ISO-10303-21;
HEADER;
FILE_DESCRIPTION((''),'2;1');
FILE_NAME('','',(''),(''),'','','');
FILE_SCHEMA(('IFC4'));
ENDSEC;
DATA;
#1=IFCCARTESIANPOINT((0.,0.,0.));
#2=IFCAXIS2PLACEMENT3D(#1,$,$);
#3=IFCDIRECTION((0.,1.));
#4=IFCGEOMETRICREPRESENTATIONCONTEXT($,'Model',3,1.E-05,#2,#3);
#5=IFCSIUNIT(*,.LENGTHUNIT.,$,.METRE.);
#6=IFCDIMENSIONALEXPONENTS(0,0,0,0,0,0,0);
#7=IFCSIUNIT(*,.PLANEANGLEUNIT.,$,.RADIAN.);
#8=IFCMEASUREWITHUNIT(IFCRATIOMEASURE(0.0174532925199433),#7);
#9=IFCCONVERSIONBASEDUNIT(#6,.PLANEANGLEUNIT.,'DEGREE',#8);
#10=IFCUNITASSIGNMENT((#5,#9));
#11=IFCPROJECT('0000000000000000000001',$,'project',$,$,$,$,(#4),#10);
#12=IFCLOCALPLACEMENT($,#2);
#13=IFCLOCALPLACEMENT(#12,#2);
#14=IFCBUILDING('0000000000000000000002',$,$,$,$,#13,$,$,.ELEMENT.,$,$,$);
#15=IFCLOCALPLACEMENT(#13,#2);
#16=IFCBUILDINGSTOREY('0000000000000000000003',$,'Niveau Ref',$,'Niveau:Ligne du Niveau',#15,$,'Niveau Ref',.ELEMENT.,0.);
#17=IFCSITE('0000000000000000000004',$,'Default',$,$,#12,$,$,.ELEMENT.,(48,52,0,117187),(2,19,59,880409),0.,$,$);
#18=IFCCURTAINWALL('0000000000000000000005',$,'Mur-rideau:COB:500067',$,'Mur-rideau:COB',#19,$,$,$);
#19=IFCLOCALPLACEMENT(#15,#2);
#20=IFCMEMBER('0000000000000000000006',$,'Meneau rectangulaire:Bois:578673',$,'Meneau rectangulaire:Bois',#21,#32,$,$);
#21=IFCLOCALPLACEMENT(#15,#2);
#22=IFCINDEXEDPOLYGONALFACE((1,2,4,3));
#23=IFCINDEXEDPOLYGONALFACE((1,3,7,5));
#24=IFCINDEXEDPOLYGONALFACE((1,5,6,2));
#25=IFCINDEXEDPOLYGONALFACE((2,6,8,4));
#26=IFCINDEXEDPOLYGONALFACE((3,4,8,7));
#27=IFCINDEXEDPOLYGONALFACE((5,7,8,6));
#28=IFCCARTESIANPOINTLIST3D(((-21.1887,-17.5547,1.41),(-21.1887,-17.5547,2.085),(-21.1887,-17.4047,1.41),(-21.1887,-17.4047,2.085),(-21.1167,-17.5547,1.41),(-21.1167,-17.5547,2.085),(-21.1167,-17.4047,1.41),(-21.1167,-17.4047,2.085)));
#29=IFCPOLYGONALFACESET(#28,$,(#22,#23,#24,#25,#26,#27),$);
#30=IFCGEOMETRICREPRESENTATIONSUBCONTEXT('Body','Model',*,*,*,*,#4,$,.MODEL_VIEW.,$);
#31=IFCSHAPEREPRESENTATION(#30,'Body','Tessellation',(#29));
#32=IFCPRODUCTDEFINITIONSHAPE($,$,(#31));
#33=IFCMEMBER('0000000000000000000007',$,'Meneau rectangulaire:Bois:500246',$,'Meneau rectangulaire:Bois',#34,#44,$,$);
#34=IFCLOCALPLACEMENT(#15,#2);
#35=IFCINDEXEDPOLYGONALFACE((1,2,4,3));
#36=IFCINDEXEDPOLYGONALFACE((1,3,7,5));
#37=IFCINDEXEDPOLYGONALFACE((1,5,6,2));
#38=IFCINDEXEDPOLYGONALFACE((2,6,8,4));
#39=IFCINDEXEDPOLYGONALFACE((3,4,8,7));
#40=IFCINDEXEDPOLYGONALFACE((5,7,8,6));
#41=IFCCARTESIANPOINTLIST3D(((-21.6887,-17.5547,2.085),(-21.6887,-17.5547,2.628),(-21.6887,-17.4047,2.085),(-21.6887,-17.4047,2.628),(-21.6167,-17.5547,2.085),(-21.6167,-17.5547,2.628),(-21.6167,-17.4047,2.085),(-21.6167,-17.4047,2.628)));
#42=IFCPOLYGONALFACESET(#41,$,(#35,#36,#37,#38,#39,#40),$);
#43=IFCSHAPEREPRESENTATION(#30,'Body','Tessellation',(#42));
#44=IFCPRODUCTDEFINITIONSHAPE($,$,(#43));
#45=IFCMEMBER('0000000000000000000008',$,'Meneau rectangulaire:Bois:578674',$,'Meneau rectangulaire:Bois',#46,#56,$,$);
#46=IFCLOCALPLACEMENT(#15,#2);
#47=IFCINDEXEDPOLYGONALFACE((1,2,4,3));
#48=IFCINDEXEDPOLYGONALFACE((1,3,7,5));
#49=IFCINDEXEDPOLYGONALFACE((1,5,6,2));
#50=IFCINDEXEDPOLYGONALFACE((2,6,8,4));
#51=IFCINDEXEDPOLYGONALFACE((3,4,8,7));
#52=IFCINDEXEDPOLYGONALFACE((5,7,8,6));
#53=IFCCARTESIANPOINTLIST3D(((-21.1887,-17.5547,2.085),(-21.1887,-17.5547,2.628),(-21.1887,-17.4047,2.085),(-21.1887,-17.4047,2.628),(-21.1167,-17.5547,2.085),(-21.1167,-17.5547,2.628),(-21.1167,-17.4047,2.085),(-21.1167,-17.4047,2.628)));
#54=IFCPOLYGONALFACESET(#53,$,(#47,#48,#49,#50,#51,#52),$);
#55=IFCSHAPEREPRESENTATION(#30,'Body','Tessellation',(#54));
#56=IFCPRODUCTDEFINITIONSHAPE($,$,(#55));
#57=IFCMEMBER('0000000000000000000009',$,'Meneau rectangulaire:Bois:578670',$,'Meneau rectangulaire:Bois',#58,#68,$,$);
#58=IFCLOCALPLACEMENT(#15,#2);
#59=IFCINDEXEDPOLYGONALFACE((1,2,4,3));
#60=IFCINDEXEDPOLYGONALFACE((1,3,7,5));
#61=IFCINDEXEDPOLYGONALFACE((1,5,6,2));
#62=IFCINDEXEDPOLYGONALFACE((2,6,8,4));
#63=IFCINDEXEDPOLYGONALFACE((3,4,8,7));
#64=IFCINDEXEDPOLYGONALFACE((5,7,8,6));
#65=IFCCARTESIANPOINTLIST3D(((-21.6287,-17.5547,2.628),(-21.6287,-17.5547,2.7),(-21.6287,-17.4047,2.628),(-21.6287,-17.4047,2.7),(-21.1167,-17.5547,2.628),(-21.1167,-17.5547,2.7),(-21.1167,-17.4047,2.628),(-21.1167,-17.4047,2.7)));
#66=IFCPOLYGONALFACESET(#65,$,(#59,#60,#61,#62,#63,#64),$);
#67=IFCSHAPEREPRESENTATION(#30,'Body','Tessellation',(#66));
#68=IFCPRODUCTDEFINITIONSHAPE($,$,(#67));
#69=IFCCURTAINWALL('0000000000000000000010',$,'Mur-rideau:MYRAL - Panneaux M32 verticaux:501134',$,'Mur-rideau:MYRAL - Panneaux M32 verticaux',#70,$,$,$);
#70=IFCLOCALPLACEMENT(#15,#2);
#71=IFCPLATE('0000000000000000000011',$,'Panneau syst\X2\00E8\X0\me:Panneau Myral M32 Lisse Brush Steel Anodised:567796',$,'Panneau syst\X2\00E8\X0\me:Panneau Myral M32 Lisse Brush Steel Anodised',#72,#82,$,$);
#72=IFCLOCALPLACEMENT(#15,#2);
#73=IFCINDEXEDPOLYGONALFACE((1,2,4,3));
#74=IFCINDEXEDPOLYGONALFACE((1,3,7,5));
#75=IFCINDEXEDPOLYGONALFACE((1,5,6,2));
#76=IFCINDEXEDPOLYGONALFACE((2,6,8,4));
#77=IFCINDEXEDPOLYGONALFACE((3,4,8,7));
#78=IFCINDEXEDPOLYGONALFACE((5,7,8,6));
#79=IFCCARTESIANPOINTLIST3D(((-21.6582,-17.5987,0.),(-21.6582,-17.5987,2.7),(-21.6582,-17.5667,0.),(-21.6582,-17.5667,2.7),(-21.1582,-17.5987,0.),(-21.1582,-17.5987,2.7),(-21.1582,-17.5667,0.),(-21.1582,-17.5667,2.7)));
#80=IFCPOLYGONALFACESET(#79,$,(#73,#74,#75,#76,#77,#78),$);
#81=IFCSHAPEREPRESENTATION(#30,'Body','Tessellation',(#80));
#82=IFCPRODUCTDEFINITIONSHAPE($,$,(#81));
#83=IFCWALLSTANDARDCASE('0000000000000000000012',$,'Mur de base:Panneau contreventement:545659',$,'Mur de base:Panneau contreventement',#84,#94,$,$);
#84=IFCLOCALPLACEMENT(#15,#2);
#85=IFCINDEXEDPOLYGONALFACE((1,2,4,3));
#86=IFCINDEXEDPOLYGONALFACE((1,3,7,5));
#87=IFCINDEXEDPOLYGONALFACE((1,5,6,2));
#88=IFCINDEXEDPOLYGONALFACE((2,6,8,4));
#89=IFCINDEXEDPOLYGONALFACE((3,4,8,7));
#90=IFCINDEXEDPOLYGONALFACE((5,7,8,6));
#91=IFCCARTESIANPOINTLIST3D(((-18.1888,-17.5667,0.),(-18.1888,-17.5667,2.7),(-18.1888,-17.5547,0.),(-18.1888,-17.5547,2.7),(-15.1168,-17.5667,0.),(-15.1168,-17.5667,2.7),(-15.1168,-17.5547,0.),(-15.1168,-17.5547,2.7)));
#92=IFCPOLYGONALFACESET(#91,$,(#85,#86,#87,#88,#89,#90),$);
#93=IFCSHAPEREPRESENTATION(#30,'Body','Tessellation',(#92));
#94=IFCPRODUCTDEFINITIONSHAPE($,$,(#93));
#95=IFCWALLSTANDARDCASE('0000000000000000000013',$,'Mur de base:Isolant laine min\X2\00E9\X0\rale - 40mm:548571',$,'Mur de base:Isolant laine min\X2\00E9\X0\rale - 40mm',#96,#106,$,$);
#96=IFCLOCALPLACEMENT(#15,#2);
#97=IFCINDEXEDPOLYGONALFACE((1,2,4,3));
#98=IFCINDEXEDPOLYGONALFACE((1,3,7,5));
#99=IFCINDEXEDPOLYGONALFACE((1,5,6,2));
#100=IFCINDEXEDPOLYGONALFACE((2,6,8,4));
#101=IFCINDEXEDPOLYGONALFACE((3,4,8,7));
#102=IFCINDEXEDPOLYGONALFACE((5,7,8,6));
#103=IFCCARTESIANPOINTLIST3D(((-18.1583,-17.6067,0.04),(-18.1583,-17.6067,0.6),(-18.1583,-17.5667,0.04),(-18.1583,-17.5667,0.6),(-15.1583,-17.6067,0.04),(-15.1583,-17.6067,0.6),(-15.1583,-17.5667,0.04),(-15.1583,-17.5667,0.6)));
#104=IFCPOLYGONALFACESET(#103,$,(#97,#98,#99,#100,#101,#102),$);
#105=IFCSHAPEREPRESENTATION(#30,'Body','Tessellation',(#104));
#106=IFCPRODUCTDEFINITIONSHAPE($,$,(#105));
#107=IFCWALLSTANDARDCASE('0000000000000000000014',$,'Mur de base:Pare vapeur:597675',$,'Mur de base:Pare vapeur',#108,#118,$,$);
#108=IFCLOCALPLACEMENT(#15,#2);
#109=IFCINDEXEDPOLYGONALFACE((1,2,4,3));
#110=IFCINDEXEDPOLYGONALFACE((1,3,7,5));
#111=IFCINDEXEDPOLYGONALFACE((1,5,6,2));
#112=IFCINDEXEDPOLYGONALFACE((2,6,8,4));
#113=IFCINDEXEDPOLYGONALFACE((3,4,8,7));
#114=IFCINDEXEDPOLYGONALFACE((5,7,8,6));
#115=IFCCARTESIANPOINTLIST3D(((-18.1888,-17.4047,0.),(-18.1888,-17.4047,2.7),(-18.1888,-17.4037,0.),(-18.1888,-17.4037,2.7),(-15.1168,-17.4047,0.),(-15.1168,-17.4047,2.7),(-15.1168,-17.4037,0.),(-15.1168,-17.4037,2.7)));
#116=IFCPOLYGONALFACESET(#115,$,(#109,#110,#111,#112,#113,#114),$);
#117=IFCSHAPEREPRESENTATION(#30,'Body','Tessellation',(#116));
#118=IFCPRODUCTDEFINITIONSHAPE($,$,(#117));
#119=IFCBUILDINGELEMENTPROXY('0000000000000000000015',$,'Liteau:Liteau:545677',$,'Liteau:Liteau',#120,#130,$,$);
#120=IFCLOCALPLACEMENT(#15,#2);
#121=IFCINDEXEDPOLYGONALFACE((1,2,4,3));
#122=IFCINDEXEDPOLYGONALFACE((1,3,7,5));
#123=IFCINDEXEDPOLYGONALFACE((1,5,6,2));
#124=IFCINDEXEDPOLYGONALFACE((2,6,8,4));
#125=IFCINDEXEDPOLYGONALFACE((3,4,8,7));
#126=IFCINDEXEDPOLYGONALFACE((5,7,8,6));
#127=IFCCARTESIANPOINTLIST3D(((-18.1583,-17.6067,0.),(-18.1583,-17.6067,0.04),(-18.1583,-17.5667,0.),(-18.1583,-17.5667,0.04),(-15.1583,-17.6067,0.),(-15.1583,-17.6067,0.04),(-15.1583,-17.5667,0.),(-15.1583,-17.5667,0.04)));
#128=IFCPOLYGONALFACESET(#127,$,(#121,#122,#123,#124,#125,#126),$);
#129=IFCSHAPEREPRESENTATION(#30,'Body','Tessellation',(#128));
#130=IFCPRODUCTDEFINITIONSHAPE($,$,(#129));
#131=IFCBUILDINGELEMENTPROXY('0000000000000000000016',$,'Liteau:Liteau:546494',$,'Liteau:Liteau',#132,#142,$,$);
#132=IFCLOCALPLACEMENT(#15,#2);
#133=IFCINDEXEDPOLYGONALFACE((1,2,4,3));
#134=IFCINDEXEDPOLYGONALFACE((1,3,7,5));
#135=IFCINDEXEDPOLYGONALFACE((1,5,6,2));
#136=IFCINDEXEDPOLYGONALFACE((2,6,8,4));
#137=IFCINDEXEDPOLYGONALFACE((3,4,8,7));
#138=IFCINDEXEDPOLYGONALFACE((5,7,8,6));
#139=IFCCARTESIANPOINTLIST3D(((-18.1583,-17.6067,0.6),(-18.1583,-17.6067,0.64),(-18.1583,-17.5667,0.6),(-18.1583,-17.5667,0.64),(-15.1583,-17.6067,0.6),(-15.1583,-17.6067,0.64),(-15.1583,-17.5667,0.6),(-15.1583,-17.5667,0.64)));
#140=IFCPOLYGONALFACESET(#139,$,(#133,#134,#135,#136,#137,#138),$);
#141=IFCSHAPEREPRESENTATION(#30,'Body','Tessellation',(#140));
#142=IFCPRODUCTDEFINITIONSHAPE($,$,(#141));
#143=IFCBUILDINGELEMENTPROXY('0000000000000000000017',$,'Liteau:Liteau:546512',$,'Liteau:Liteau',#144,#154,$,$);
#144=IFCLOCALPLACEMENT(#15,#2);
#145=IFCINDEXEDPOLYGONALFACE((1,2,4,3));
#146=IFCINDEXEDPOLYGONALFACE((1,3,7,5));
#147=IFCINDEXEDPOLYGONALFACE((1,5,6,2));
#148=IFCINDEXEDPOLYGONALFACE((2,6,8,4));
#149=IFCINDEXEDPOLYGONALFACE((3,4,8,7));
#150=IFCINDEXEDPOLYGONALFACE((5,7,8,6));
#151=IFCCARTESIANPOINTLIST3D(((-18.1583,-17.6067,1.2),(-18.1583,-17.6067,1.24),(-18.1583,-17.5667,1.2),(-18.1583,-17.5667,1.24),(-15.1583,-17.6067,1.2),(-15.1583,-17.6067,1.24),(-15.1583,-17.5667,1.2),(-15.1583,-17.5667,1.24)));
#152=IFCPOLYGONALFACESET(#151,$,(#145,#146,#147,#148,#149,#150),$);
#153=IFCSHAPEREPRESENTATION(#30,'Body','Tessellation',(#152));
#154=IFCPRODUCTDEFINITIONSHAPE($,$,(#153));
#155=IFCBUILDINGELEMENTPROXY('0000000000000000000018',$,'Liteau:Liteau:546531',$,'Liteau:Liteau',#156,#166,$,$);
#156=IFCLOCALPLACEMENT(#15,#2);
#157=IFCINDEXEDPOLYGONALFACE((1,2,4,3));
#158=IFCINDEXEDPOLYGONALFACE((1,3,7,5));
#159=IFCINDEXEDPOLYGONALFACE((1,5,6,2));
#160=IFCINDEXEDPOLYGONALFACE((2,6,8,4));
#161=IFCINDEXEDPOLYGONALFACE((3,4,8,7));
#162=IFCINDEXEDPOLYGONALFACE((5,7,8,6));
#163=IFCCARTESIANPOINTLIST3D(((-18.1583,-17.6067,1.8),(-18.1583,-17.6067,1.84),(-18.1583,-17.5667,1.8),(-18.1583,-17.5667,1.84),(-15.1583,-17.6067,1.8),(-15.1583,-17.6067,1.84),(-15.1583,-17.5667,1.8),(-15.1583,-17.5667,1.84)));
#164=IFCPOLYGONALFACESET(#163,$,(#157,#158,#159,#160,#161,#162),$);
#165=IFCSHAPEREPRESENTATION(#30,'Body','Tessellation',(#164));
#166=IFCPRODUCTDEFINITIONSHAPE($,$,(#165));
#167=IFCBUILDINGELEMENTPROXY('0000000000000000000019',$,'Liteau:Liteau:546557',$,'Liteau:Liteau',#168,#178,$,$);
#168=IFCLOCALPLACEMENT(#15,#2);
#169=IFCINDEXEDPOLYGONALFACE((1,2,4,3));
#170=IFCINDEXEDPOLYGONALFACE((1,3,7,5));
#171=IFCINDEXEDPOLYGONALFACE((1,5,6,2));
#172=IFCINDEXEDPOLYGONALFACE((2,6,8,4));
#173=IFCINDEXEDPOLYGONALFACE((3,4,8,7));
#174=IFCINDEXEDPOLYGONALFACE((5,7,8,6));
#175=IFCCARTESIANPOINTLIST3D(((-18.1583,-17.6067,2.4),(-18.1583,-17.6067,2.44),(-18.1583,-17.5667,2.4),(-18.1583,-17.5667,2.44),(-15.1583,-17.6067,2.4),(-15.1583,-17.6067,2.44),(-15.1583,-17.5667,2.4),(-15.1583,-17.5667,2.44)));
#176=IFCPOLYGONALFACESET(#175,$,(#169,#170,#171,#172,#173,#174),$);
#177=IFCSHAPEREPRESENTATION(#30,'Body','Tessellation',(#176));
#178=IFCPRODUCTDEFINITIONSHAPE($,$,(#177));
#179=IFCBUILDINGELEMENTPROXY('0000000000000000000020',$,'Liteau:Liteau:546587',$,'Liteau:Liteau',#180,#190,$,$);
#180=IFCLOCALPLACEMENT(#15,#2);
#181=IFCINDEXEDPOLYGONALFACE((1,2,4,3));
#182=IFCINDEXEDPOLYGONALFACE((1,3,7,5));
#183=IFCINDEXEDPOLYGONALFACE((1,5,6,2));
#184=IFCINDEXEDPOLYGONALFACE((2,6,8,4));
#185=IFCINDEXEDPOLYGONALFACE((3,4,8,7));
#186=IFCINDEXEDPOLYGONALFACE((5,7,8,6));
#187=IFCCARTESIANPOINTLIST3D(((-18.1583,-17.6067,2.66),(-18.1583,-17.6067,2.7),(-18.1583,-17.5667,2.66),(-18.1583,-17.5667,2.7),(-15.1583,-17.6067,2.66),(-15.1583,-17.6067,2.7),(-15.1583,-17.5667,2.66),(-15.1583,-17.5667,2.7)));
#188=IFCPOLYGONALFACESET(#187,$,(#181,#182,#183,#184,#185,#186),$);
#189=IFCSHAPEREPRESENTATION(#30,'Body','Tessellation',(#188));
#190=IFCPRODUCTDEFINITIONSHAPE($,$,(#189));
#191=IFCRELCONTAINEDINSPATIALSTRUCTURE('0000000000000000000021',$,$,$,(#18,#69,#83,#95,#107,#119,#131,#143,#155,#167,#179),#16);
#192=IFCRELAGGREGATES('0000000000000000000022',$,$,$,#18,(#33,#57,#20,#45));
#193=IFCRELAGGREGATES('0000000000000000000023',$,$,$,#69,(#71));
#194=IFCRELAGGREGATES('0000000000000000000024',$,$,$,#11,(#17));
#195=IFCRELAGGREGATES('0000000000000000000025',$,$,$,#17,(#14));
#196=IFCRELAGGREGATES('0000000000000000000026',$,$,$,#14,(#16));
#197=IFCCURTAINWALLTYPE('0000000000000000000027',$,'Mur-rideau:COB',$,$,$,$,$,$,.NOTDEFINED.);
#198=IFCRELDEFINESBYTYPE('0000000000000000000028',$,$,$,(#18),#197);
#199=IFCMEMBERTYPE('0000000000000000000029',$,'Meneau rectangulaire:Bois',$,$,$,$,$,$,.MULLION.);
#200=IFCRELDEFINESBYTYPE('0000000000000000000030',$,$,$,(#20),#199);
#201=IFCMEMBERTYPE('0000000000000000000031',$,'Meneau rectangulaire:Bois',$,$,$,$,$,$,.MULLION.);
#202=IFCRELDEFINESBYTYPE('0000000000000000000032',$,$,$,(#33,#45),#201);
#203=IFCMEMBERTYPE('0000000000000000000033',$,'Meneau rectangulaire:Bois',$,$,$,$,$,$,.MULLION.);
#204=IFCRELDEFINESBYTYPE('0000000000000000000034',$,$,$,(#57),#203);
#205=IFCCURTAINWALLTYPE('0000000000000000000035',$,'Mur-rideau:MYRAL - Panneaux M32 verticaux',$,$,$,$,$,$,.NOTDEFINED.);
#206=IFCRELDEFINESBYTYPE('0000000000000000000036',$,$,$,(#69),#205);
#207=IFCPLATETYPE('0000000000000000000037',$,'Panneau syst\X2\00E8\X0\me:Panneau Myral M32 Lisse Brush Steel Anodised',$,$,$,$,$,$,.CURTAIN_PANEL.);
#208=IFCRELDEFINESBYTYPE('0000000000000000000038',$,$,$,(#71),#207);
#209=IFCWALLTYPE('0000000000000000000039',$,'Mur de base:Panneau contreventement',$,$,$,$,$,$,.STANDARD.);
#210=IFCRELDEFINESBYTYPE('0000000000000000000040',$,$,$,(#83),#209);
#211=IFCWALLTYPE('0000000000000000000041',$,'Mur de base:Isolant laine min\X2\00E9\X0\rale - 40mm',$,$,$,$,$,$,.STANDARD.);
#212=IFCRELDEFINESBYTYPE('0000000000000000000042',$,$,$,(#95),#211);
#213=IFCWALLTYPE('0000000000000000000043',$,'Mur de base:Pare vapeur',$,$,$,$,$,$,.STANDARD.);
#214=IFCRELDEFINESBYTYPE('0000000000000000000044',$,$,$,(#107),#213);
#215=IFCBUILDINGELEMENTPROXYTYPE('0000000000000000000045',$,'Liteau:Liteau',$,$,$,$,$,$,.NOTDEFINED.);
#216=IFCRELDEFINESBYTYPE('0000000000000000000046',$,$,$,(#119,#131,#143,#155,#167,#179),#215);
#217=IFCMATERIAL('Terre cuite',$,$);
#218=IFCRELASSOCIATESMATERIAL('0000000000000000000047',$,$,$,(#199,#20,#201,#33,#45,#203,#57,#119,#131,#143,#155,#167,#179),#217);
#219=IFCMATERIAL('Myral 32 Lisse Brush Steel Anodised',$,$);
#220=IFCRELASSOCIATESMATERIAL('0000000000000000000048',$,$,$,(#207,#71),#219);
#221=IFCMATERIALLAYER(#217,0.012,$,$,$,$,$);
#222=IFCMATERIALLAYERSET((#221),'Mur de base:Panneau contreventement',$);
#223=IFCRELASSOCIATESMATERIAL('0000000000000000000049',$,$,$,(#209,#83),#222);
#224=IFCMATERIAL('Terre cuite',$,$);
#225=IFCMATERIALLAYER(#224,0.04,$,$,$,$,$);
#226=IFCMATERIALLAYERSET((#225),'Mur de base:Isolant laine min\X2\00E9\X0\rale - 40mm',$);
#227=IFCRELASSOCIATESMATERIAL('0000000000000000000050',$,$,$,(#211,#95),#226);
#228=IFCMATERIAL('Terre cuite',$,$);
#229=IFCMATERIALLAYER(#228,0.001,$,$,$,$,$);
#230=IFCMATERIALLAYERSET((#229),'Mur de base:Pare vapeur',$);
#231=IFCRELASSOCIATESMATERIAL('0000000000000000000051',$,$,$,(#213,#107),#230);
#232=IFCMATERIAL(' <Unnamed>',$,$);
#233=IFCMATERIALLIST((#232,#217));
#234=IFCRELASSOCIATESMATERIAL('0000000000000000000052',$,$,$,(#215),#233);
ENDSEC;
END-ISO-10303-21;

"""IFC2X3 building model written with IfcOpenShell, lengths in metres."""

from ifc_helpers import new_model, entity, si_unit, converted_unit, direction, frame, frame_2d, origin, origin_2d_with_axis, place, context, subcontext, project, spatial, rectangle, extrude, source, transform, mapped, material, material_list, layer, layer_set, layer_usage, type_object, type_shapes, element, aggregate, save


model = new_model("IFC2X3")

# Units and contexts
model_context = context("Model", 3, precision=1e-05, world=origin(), true_north=direction((0.0, 1.0)))
body_context = subcontext(model_context, "Body", "Model", "MODEL_VIEW")
ifc_project = project(units=[si_unit("LENGTHUNIT", "METRE"), converted_unit("PLANEANGLEUNIT", "DEGREE", entity("IfcRatioMeasure", 0.0174532925199433), si_unit("PLANEANGLEUNIT", "RADIAN"), dimensions=[0, 0, 0, 0, 0, 0, 0])], contexts=[model_context])

# Site, building, storey
site_placement = place(None, origin())
site = spatial("IfcSite", under=ifc_project, at=site_placement, Name="Default", CompositionType="ELEMENT", RefLatitude=(48, 52, 0, 117187), RefLongitude=(2, 19, 59, 880409), RefElevation=0.0)
building_placement = place(site_placement, origin())
building = spatial("IfcBuilding", under=site, at=building_placement, CompositionType="ELEMENT")
storey_placement = place(building_placement, origin())
storey = spatial("IfcBuildingStorey", under=building, at=storey_placement, Name="Niveau Ref", ObjectType="Niveau:Ligne du Niveau", LongName="Niveau Ref", CompositionType="ELEMENT", Elevation=0.0)

# Curtain wall, members
curtain_wall_type_1 = type_object("IfcCurtainWallType", Name="Mur-rideau:COB", PredefinedType="NOTDEFINED")
ifc_material_1 = material(Name="Terre cuite")
curtain_wall_1_placement = place(storey_placement, origin())
curtain_wall_1 = element("IfcCurtainWall", 1, at=curtain_wall_1_placement, inside=storey, type_object=curtain_wall_type_1, Name="Mur-rideau:COB:500067", ObjectType="Mur-rideau:COB")
member_type_1 = type_object("IfcMemberType", Name="Meneau rectangulaire:Bois", PredefinedType="MULLION", material=ifc_material_1)
shared_shape_1 = source(origin(), body_context, "Body", "SweptSolid", [
    extrude(rectangle(XDim=0.15, YDim=0.072, at=origin_2d_with_axis()), frame((-0.024, 0.0, -0.675), z_axis=(0.0, 0.0, 1.0), x_axis=(0.0, -1.0, 0.0)), (0.0, 0.0, 1.0), 0.675),
])
type_shapes(member_type_1, [shared_shape_1])
member_1_placement = place(storey_placement, frame((-21.1287, -17.4797, 1.41), z_axis=(0.0, 0.0, -1.0), x_axis=(1.0, 0.0, 0.0)))
member_1 = element("IfcMember", 2, at=member_1_placement, type_object=member_type_1, material=ifc_material_1, Name="Meneau rectangulaire:Bois:578673", ObjectType="Meneau rectangulaire:Bois", context=body_context, shape_type="MappedRepresentation", body=[
    mapped(shared_shape_1, transform((0.0, 0.0, 0.0), scale=1.0)),
])
member_type_2 = type_object("IfcMemberType", Name="Meneau rectangulaire:Bois", PredefinedType="MULLION", material=ifc_material_1)
shared_shape_2 = source(origin(), body_context, "Body", "SweptSolid", [
    extrude(rectangle(XDim=0.15, YDim=0.072, at=origin_2d_with_axis()), frame((-0.024, 0.0, -0.543), z_axis=(0.0, 0.0, 1.0), x_axis=(0.0, -1.0, 0.0)), (0.0, 0.0, 1.0), 0.543),
])
type_shapes(member_type_2, [shared_shape_2])
member_2_placement = place(storey_placement, frame((-21.6287, -17.4797, 2.085), z_axis=(0.0, 0.0, -1.0), x_axis=(1.0, 0.0, 0.0)))
member_2 = element("IfcMember", 3, at=member_2_placement, type_object=member_type_2, material=ifc_material_1, Name="Meneau rectangulaire:Bois:500246", ObjectType="Meneau rectangulaire:Bois", context=body_context, shape_type="MappedRepresentation", body=[
    mapped(shared_shape_2, transform((0.0, 0.0, 0.0), scale=1.0)),
])
member_3_placement = place(storey_placement, frame((-21.1287, -17.4797, 2.085), z_axis=(0.0, 0.0, -1.0), x_axis=(1.0, 0.0, 0.0)))
member_3 = element("IfcMember", 4, at=member_3_placement, type_object=member_type_2, material=ifc_material_1, Name="Meneau rectangulaire:Bois:578674", ObjectType="Meneau rectangulaire:Bois", context=body_context, shape_type="MappedRepresentation", body=[
    mapped(shared_shape_2, transform((0.0, 0.0, 0.0), scale=1.0)),
])
member_type_3 = type_object("IfcMemberType", Name="Meneau rectangulaire:Bois", PredefinedType="MULLION", material=ifc_material_1)
shared_shape_3 = source(origin(), body_context, "Body", "SweptSolid", [
    extrude(rectangle(XDim=0.15, YDim=0.072, at=origin_2d_with_axis()), frame((-0.036, 0.0, -0.512), z_axis=(0.0, 0.0, 1.0), x_axis=(0.0, -1.0, 0.0)), (0.0, 0.0, 1.0), 0.512),
])
type_shapes(member_type_3, [shared_shape_3])
member_4_placement = place(storey_placement, frame((-21.1167, -17.4797, 2.7), z_axis=(1.0, 0.0, 0.0), x_axis=(0.0, 0.0, 1.0)))
member_4 = element("IfcMember", 5, at=member_4_placement, type_object=member_type_3, material=ifc_material_1, Name="Meneau rectangulaire:Bois:578670", ObjectType="Meneau rectangulaire:Bois", context=body_context, shape_type="MappedRepresentation", body=[
    mapped(shared_shape_3, transform((0.0, 0.0, 0.0), scale=1.0)),
])
aggregate(curtain_wall_1, [member_2, member_4, member_1, member_3])

# Curtain wall, plate
curtain_wall_type_2 = type_object("IfcCurtainWallType", Name="Mur-rideau:MYRAL - Panneaux M32 verticaux", PredefinedType="NOTDEFINED")
curtain_wall_2_placement = place(storey_placement, origin())
curtain_wall_2 = element("IfcCurtainWall", 6, at=curtain_wall_2_placement, inside=storey, type_object=curtain_wall_type_2, Name="Mur-rideau:MYRAL - Panneaux M32 verticaux:501134", ObjectType="Mur-rideau:MYRAL - Panneaux M32 verticaux")
ifc_material_2 = material(Name="Myral 32 Lisse Brush Steel Anodised")
plate_type = type_object("IfcPlateType", Name="Panneau système:Panneau Myral M32 Lisse Brush Steel Anodised", PredefinedType="CURTAIN_PANEL", material=ifc_material_2)
shared_shape_4 = source(origin(), body_context, "Body", "SweptSolid", [
    extrude(rectangle(XDim=0.032, YDim=0.5, at=origin_2d_with_axis()), frame((0.0, -0.016, 0.0), z_axis=(0.0, 0.0, 1.0), x_axis=(0.0, 1.0, 0.0)), (0.0, 0.0, 1.0), 2.7),
])
type_shapes(plate_type, [shared_shape_4])
plate_placement = place(curtain_wall_2_placement, frame((-21.4082, -17.5667, 0.0)))
plate = element("IfcPlate", 7, at=plate_placement, type_object=plate_type, material=ifc_material_2, Name="Panneau système:Panneau Myral M32 Lisse Brush Steel Anodised:567796", ObjectType="Panneau système:Panneau Myral M32 Lisse Brush Steel Anodised", context=body_context, shape_type="MappedRepresentation", body=[
    mapped(shared_shape_4, transform((0.0, 0.0, 0.0), scale=1.0)),
])
aggregate(curtain_wall_2, [plate])

# Walls
ifc_layer_1 = layer(ifc_material_1, 0.012)
ifc_layer_set_1 = layer_set([ifc_layer_1], Name="Mur de base:Panneau contreventement")
ifc_layer_usage_1 = layer_usage(ifc_layer_set_1, "AXIS2", "NEGATIVE", 0.006)
wall_type_1 = type_object("IfcWallType", Name="Mur de base:Panneau contreventement", PredefinedType="STANDARD", material=ifc_layer_set_1)
wall_1_placement = place(storey_placement, frame((-18.1888, -17.5607, 0.0)))
element("IfcWallStandardCase", 8, at=wall_1_placement, inside=storey, type_object=wall_type_1, material=ifc_layer_usage_1, Name="Mur de base:Panneau contreventement:545659", ObjectType="Mur de base:Panneau contreventement", context=body_context, shape_type="SweptSolid", body=[
    extrude(rectangle(XDim=3.072, YDim=0.012, at=frame_2d((1.536, 0.0), x_axis=(-1.0, 0.0))), origin(), (0.0, 0.0, 1.0), 2.7),
])
ifc_material_3 = material(Name="Terre cuite")
ifc_layer_2 = layer(ifc_material_3, 0.04)
ifc_layer_set_2 = layer_set([ifc_layer_2], Name="Mur de base:Isolant laine minérale - 40mm")
ifc_layer_usage_2 = layer_usage(ifc_layer_set_2, "AXIS2", "NEGATIVE", 0.02)
wall_type_2 = type_object("IfcWallType", Name="Mur de base:Isolant laine minérale - 40mm", PredefinedType="STANDARD", material=ifc_layer_set_2)
wall_2_placement = place(storey_placement, frame((-18.1583, -17.5867, 0.04)))
element("IfcWallStandardCase", 9, at=wall_2_placement, inside=storey, type_object=wall_type_2, material=ifc_layer_usage_2, Name="Mur de base:Isolant laine minérale - 40mm:548571", ObjectType="Mur de base:Isolant laine minérale - 40mm", context=body_context, shape_type="SweptSolid", body=[
    extrude(rectangle(XDim=3.0, YDim=0.04, at=frame_2d((1.5, 0.0), x_axis=(-1.0, 0.0))), origin(), (0.0, 0.0, 1.0), 0.56),
])
ifc_material_4 = material(Name="Terre cuite")
ifc_layer_3 = layer(ifc_material_4, 0.001)
ifc_layer_set_3 = layer_set([ifc_layer_3], Name="Mur de base:Pare vapeur")
ifc_layer_usage_3 = layer_usage(ifc_layer_set_3, "AXIS2", "NEGATIVE", 0.0005)
wall_type_3 = type_object("IfcWallType", Name="Mur de base:Pare vapeur", PredefinedType="STANDARD", material=ifc_layer_set_3)
wall_3_placement = place(storey_placement, frame((-18.1888, -17.4042, 0.0)))
element("IfcWallStandardCase", 10, at=wall_3_placement, inside=storey, type_object=wall_type_3, material=ifc_layer_usage_3, Name="Mur de base:Pare vapeur:597675", ObjectType="Mur de base:Pare vapeur", context=body_context, shape_type="SweptSolid", body=[
    extrude(rectangle(XDim=3.072, YDim=0.001, at=frame_2d((1.536, 0.0), x_axis=(-1.0, 0.0))), origin(), (0.0, 0.0, 1.0), 2.7),
])

# Building element proxies
ifc_material_5 = material(Name=" <Unnamed>")
ifc_material_list = material_list([ifc_material_5, ifc_material_1])
building_element_proxy_type = type_object("IfcBuildingElementProxyType", Name="Liteau:Liteau", PredefinedType="NOTDEFINED", material=ifc_material_list)
shared_shape_5 = source(origin(), body_context, "Body", "SweptSolid", [
    extrude(rectangle(XDim=3.0, YDim=0.04, at=origin_2d_with_axis()), frame((1.5, -0.02, 0.0), z_axis=(0.0, 0.0, 1.0), x_axis=(-1.0, 0.0, 0.0)), (0.0, 0.0, 1.0), 0.04),
])
type_shapes(building_element_proxy_type, [shared_shape_5])
for number, where, name in (
    (11, (-18.1583, -17.5667, 0.0), "Liteau:Liteau:545677"),
    (12, (-18.1583, -17.5667, 0.6), "Liteau:Liteau:546494"),
    (13, (-18.1583, -17.5667, 1.2), "Liteau:Liteau:546512"),
    (14, (-18.1583, -17.5667, 1.8), "Liteau:Liteau:546531"),
    (15, (-18.1583, -17.5667, 2.4), "Liteau:Liteau:546557"),
    (16, (-18.1583, -17.5667, 2.66), "Liteau:Liteau:546587"),
):
    element("IfcBuildingElementProxy", number, at=place(storey_placement, frame(where)), inside=storey, type_object=building_element_proxy_type, material=ifc_material_1, Name=name, ObjectType="Liteau:Liteau", context=body_context, shape_type="MappedRepresentation", body=[
        mapped(shared_shape_5, transform((0.0, 0.0, 0.0), scale=1.0)),
    ])

save(model, "model.ifc")
